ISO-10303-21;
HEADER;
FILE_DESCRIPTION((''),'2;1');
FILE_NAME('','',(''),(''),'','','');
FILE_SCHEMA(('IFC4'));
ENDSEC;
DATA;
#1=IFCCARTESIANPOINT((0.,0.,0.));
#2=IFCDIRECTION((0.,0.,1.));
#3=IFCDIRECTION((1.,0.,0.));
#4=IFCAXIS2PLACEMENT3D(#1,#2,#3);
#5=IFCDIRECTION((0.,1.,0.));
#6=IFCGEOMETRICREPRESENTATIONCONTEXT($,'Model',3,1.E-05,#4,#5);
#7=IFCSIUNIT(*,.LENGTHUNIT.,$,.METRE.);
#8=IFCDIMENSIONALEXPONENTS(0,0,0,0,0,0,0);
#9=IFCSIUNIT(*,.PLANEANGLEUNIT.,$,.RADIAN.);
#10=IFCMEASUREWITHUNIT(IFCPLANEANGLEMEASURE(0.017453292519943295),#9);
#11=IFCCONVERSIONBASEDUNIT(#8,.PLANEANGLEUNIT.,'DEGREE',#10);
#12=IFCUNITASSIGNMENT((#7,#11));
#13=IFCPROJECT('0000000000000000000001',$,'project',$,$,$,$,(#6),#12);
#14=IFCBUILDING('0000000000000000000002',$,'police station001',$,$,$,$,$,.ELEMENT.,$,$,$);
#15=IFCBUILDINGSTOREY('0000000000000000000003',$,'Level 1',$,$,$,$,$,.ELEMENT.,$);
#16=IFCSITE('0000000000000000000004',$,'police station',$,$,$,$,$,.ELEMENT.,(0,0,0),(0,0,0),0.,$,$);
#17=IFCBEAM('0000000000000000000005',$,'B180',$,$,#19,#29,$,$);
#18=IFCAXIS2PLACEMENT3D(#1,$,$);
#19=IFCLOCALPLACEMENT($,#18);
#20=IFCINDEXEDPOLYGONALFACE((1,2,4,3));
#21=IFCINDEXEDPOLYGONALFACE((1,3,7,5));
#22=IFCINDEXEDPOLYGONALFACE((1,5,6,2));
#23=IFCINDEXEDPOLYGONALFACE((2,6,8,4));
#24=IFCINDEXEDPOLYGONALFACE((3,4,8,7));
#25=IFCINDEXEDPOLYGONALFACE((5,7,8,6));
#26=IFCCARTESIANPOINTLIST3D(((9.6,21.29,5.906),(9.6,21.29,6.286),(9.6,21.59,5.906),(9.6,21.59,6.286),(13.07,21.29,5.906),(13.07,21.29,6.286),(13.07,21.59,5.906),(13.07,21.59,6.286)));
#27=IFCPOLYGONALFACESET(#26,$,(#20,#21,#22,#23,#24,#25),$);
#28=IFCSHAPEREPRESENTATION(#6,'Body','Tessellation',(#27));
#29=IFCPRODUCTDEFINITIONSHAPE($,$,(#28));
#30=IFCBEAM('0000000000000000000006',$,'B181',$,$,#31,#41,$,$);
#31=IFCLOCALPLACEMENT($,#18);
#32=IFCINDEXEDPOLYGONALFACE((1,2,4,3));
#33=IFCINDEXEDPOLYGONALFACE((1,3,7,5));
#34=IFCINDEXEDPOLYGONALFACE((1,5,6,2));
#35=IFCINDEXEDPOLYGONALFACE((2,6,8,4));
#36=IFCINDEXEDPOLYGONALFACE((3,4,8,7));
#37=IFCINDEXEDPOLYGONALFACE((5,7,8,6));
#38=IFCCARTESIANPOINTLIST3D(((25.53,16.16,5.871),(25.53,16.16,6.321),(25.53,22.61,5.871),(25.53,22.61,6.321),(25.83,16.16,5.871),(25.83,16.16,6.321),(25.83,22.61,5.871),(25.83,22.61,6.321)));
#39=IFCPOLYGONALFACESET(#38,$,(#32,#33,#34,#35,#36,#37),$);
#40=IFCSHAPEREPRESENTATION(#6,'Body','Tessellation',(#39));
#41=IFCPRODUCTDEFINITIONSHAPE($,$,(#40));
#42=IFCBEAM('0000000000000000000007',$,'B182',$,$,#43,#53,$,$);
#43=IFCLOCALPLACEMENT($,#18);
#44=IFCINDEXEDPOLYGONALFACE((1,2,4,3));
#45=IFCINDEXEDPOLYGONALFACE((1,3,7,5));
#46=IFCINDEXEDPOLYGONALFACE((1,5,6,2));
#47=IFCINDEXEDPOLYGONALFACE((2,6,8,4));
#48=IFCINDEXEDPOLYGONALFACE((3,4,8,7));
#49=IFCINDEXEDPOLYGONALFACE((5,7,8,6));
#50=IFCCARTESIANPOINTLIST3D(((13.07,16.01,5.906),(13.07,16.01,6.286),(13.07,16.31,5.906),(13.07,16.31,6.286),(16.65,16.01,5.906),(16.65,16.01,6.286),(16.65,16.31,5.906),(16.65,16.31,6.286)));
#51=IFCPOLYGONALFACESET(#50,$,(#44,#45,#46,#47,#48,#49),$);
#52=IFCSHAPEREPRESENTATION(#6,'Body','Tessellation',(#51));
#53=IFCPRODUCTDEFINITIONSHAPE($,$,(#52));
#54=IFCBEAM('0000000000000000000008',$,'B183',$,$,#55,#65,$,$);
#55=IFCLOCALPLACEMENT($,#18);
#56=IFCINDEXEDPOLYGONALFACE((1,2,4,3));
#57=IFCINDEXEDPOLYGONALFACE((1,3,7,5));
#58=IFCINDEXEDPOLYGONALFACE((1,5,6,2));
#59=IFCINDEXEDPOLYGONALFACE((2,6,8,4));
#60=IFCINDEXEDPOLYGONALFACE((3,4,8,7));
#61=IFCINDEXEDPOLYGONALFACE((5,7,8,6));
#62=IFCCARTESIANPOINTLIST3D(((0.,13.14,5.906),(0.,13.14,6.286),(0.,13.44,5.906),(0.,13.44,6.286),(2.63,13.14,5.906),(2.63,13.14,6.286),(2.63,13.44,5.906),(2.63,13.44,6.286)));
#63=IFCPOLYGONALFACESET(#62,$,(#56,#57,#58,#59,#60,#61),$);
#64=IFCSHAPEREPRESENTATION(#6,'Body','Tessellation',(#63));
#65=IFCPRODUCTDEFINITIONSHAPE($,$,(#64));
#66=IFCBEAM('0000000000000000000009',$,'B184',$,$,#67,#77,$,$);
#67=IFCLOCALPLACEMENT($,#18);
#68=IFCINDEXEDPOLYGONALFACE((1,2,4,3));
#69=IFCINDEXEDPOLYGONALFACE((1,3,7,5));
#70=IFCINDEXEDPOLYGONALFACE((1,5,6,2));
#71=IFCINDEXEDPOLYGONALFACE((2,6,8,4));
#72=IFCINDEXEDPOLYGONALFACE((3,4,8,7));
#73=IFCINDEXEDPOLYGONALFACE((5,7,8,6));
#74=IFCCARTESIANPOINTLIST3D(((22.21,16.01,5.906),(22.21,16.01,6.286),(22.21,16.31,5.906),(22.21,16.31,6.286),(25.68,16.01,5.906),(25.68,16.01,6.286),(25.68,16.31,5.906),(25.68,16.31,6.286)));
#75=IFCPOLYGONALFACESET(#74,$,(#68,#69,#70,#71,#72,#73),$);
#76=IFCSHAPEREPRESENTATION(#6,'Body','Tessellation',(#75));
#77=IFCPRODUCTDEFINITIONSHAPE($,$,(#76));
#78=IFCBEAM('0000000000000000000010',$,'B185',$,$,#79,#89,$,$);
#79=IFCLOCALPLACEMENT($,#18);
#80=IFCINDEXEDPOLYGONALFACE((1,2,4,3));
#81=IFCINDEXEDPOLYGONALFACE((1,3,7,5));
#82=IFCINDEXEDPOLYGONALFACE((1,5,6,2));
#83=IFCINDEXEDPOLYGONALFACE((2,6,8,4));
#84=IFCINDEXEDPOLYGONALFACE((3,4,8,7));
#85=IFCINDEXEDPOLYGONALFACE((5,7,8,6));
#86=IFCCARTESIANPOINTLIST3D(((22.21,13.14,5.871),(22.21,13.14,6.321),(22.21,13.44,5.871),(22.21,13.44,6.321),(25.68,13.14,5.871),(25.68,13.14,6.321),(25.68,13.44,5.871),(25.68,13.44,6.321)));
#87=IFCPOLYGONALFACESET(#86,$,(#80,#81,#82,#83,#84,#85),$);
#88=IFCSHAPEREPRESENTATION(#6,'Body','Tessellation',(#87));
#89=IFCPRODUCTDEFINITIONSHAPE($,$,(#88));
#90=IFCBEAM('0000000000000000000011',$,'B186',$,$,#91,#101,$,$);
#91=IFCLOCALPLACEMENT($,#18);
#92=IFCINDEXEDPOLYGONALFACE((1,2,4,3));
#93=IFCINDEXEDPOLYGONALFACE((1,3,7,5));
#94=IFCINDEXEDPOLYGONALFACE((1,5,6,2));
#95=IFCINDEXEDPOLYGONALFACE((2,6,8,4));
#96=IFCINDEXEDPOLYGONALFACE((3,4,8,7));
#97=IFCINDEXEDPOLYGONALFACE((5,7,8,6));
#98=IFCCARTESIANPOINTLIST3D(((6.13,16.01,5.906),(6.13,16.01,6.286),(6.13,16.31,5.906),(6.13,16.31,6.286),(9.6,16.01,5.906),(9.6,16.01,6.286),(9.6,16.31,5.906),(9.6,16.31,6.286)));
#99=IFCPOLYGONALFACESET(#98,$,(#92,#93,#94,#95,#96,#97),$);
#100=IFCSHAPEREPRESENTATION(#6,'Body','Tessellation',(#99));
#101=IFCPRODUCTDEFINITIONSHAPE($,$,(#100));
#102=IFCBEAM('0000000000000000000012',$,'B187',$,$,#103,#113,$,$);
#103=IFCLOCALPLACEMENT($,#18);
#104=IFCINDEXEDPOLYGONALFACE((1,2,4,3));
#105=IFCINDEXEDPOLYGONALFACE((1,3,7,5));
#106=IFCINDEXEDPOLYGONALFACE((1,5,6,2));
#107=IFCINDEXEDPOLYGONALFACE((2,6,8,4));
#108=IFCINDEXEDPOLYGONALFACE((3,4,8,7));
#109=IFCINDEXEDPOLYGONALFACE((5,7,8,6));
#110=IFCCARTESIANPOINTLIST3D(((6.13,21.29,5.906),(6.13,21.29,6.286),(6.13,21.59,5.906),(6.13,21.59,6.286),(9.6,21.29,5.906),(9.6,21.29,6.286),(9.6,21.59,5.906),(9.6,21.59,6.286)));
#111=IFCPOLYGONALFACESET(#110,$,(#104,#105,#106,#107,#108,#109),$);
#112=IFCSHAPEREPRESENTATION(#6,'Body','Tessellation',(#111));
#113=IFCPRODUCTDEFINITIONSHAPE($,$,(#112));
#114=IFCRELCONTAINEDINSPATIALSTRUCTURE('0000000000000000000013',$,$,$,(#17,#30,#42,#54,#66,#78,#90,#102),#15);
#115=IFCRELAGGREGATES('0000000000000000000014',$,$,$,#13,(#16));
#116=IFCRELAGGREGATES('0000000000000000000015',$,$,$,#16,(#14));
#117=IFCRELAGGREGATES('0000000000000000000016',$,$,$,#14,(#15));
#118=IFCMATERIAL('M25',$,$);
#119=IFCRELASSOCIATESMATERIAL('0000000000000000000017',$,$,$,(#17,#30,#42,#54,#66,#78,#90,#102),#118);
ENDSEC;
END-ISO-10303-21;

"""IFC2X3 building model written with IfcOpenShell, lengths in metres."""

from ifc_helpers import new_model, entity, si_unit, converted_unit, direction, frame, frame_2d, origin_with_axes, place, context, project, spatial, rectangle, extrude, material, element, save


model = new_model("IFC2X3")

# Units and contexts
model_context = context("Model", 3, precision=1e-05, world=origin_with_axes(), true_north=direction((0.0, 1.0, 0.0)))
ifc_project = project(units=[si_unit("LENGTHUNIT", "METRE"), converted_unit("PLANEANGLEUNIT", "DEGREE", entity("IfcPlaneAngleMeasure", 0.017453292519943295), si_unit("PLANEANGLEUNIT", "RADIAN"), dimensions=[0, 0, 0, 0, 0, 0, 0])], contexts=[model_context])

# Site, building, storey
site = spatial("IfcSite", under=ifc_project, Name="police station", CompositionType="ELEMENT", RefLatitude=(0, 0, 0), RefLongitude=(0, 0, 0), RefElevation=0.0)
building = spatial("IfcBuilding", under=site, Name="police station001", CompositionType="ELEMENT")
storey = spatial("IfcBuildingStorey", under=building, Name="Level 1", CompositionType="ELEMENT")

# Beams
ifc_material = material(Name="M25")
placement = place(None, origin_with_axes())
element("IfcBeam", 1, at=placement, inside=storey, material=ifc_material, Name="B180", context=model_context, shape_type="SweptSolid", body=[
    extrude(rectangle(XDim=0.3, YDim=0.38, at=frame_2d((0.0, 0.0), x_axis=(0.0, 1.0, 0.0))), frame((13.07, 21.44, 6.096), z_axis=(-1.0, 0.0, 0.0), x_axis=(0.0, 0.0, -1.0)), (0.0, 0.0, 1.0), 3.47),
])
element("IfcBeam", 2, at=placement, inside=storey, material=ifc_material, Name="B181", context=model_context, shape_type="SweptSolid", body=[
    extrude(rectangle(XDim=0.3, YDim=0.45, at=frame_2d((0.0, 0.0), x_axis=(0.0, 1.0, 0.0))), frame((25.68, 22.61, 6.096), z_axis=(0.0, -1.0, 0.0), x_axis=(0.0, 0.0, -1.0)), (0.0, 0.0, 1.0), 6.45),
])
element("IfcBeam", 3, at=placement, inside=storey, material=ifc_material, Name="B182", context=model_context, shape_type="SweptSolid", body=[
    extrude(rectangle(XDim=0.3, YDim=0.38, at=frame_2d((0.0, 0.0), x_axis=(0.0, 1.0, 0.0))), frame((16.65, 16.16, 6.096), z_axis=(-1.0, 0.0, 0.0), x_axis=(0.0, 0.0, -1.0)), (0.0, 0.0, 1.0), 3.58),
])
element("IfcBeam", 4, at=placement, inside=storey, material=ifc_material, Name="B183", context=model_context, shape_type="SweptSolid", body=[
    extrude(rectangle(XDim=0.3, YDim=0.38, at=frame_2d((0.0, 0.0), x_axis=(0.0, 1.0, 0.0))), frame((0.0, 13.29, 6.096), z_axis=(1.0, 0.0, 0.0), x_axis=(0.0, 0.0, -1.0)), (0.0, 0.0, 1.0), 2.63),
])
element("IfcBeam", 5, at=placement, inside=storey, material=ifc_material, Name="B184", context=model_context, shape_type="SweptSolid", body=[
    extrude(rectangle(XDim=0.3, YDim=0.38, at=frame_2d((0.0, 0.0), x_axis=(0.0, 1.0, 0.0))), frame((22.21, 16.16, 6.096), z_axis=(1.0, 0.0, 0.0), x_axis=(0.0, 0.0, -1.0)), (0.0, 0.0, 1.0), 3.47),
])
element("IfcBeam", 6, at=placement, inside=storey, material=ifc_material, Name="B185", context=model_context, shape_type="SweptSolid", body=[
    extrude(rectangle(XDim=0.3, YDim=0.45, at=frame_2d((0.0, 0.0), x_axis=(0.0, 1.0, 0.0))), frame((25.68, 13.29, 6.096), z_axis=(-1.0, 0.0, 0.0), x_axis=(0.0, 0.0, -1.0)), (0.0, 0.0, 1.0), 3.47),
])
element("IfcBeam", 7, at=placement, inside=storey, material=ifc_material, Name="B186", context=model_context, shape_type="SweptSolid", body=[
    extrude(rectangle(XDim=0.3, YDim=0.38, at=frame_2d((0.0, 0.0), x_axis=(0.0, 1.0, 0.0))), frame((9.6, 16.16, 6.096), z_axis=(-1.0, 0.0, 0.0), x_axis=(0.0, 0.0, -1.0)), (0.0, 0.0, 1.0), 3.47),
])
element("IfcBeam", 8, at=placement, inside=storey, material=ifc_material, Name="B187", context=model_context, shape_type="SweptSolid", body=[
    extrude(rectangle(XDim=0.3, YDim=0.38, at=frame_2d((0.0, 0.0), x_axis=(0.0, 1.0, 0.0))), frame((9.6, 21.44, 6.096), z_axis=(-1.0, 0.0, 0.0), x_axis=(0.0, 0.0, -1.0)), (0.0, 0.0, 1.0), 3.47),
])

save(model, "model.ifc")
